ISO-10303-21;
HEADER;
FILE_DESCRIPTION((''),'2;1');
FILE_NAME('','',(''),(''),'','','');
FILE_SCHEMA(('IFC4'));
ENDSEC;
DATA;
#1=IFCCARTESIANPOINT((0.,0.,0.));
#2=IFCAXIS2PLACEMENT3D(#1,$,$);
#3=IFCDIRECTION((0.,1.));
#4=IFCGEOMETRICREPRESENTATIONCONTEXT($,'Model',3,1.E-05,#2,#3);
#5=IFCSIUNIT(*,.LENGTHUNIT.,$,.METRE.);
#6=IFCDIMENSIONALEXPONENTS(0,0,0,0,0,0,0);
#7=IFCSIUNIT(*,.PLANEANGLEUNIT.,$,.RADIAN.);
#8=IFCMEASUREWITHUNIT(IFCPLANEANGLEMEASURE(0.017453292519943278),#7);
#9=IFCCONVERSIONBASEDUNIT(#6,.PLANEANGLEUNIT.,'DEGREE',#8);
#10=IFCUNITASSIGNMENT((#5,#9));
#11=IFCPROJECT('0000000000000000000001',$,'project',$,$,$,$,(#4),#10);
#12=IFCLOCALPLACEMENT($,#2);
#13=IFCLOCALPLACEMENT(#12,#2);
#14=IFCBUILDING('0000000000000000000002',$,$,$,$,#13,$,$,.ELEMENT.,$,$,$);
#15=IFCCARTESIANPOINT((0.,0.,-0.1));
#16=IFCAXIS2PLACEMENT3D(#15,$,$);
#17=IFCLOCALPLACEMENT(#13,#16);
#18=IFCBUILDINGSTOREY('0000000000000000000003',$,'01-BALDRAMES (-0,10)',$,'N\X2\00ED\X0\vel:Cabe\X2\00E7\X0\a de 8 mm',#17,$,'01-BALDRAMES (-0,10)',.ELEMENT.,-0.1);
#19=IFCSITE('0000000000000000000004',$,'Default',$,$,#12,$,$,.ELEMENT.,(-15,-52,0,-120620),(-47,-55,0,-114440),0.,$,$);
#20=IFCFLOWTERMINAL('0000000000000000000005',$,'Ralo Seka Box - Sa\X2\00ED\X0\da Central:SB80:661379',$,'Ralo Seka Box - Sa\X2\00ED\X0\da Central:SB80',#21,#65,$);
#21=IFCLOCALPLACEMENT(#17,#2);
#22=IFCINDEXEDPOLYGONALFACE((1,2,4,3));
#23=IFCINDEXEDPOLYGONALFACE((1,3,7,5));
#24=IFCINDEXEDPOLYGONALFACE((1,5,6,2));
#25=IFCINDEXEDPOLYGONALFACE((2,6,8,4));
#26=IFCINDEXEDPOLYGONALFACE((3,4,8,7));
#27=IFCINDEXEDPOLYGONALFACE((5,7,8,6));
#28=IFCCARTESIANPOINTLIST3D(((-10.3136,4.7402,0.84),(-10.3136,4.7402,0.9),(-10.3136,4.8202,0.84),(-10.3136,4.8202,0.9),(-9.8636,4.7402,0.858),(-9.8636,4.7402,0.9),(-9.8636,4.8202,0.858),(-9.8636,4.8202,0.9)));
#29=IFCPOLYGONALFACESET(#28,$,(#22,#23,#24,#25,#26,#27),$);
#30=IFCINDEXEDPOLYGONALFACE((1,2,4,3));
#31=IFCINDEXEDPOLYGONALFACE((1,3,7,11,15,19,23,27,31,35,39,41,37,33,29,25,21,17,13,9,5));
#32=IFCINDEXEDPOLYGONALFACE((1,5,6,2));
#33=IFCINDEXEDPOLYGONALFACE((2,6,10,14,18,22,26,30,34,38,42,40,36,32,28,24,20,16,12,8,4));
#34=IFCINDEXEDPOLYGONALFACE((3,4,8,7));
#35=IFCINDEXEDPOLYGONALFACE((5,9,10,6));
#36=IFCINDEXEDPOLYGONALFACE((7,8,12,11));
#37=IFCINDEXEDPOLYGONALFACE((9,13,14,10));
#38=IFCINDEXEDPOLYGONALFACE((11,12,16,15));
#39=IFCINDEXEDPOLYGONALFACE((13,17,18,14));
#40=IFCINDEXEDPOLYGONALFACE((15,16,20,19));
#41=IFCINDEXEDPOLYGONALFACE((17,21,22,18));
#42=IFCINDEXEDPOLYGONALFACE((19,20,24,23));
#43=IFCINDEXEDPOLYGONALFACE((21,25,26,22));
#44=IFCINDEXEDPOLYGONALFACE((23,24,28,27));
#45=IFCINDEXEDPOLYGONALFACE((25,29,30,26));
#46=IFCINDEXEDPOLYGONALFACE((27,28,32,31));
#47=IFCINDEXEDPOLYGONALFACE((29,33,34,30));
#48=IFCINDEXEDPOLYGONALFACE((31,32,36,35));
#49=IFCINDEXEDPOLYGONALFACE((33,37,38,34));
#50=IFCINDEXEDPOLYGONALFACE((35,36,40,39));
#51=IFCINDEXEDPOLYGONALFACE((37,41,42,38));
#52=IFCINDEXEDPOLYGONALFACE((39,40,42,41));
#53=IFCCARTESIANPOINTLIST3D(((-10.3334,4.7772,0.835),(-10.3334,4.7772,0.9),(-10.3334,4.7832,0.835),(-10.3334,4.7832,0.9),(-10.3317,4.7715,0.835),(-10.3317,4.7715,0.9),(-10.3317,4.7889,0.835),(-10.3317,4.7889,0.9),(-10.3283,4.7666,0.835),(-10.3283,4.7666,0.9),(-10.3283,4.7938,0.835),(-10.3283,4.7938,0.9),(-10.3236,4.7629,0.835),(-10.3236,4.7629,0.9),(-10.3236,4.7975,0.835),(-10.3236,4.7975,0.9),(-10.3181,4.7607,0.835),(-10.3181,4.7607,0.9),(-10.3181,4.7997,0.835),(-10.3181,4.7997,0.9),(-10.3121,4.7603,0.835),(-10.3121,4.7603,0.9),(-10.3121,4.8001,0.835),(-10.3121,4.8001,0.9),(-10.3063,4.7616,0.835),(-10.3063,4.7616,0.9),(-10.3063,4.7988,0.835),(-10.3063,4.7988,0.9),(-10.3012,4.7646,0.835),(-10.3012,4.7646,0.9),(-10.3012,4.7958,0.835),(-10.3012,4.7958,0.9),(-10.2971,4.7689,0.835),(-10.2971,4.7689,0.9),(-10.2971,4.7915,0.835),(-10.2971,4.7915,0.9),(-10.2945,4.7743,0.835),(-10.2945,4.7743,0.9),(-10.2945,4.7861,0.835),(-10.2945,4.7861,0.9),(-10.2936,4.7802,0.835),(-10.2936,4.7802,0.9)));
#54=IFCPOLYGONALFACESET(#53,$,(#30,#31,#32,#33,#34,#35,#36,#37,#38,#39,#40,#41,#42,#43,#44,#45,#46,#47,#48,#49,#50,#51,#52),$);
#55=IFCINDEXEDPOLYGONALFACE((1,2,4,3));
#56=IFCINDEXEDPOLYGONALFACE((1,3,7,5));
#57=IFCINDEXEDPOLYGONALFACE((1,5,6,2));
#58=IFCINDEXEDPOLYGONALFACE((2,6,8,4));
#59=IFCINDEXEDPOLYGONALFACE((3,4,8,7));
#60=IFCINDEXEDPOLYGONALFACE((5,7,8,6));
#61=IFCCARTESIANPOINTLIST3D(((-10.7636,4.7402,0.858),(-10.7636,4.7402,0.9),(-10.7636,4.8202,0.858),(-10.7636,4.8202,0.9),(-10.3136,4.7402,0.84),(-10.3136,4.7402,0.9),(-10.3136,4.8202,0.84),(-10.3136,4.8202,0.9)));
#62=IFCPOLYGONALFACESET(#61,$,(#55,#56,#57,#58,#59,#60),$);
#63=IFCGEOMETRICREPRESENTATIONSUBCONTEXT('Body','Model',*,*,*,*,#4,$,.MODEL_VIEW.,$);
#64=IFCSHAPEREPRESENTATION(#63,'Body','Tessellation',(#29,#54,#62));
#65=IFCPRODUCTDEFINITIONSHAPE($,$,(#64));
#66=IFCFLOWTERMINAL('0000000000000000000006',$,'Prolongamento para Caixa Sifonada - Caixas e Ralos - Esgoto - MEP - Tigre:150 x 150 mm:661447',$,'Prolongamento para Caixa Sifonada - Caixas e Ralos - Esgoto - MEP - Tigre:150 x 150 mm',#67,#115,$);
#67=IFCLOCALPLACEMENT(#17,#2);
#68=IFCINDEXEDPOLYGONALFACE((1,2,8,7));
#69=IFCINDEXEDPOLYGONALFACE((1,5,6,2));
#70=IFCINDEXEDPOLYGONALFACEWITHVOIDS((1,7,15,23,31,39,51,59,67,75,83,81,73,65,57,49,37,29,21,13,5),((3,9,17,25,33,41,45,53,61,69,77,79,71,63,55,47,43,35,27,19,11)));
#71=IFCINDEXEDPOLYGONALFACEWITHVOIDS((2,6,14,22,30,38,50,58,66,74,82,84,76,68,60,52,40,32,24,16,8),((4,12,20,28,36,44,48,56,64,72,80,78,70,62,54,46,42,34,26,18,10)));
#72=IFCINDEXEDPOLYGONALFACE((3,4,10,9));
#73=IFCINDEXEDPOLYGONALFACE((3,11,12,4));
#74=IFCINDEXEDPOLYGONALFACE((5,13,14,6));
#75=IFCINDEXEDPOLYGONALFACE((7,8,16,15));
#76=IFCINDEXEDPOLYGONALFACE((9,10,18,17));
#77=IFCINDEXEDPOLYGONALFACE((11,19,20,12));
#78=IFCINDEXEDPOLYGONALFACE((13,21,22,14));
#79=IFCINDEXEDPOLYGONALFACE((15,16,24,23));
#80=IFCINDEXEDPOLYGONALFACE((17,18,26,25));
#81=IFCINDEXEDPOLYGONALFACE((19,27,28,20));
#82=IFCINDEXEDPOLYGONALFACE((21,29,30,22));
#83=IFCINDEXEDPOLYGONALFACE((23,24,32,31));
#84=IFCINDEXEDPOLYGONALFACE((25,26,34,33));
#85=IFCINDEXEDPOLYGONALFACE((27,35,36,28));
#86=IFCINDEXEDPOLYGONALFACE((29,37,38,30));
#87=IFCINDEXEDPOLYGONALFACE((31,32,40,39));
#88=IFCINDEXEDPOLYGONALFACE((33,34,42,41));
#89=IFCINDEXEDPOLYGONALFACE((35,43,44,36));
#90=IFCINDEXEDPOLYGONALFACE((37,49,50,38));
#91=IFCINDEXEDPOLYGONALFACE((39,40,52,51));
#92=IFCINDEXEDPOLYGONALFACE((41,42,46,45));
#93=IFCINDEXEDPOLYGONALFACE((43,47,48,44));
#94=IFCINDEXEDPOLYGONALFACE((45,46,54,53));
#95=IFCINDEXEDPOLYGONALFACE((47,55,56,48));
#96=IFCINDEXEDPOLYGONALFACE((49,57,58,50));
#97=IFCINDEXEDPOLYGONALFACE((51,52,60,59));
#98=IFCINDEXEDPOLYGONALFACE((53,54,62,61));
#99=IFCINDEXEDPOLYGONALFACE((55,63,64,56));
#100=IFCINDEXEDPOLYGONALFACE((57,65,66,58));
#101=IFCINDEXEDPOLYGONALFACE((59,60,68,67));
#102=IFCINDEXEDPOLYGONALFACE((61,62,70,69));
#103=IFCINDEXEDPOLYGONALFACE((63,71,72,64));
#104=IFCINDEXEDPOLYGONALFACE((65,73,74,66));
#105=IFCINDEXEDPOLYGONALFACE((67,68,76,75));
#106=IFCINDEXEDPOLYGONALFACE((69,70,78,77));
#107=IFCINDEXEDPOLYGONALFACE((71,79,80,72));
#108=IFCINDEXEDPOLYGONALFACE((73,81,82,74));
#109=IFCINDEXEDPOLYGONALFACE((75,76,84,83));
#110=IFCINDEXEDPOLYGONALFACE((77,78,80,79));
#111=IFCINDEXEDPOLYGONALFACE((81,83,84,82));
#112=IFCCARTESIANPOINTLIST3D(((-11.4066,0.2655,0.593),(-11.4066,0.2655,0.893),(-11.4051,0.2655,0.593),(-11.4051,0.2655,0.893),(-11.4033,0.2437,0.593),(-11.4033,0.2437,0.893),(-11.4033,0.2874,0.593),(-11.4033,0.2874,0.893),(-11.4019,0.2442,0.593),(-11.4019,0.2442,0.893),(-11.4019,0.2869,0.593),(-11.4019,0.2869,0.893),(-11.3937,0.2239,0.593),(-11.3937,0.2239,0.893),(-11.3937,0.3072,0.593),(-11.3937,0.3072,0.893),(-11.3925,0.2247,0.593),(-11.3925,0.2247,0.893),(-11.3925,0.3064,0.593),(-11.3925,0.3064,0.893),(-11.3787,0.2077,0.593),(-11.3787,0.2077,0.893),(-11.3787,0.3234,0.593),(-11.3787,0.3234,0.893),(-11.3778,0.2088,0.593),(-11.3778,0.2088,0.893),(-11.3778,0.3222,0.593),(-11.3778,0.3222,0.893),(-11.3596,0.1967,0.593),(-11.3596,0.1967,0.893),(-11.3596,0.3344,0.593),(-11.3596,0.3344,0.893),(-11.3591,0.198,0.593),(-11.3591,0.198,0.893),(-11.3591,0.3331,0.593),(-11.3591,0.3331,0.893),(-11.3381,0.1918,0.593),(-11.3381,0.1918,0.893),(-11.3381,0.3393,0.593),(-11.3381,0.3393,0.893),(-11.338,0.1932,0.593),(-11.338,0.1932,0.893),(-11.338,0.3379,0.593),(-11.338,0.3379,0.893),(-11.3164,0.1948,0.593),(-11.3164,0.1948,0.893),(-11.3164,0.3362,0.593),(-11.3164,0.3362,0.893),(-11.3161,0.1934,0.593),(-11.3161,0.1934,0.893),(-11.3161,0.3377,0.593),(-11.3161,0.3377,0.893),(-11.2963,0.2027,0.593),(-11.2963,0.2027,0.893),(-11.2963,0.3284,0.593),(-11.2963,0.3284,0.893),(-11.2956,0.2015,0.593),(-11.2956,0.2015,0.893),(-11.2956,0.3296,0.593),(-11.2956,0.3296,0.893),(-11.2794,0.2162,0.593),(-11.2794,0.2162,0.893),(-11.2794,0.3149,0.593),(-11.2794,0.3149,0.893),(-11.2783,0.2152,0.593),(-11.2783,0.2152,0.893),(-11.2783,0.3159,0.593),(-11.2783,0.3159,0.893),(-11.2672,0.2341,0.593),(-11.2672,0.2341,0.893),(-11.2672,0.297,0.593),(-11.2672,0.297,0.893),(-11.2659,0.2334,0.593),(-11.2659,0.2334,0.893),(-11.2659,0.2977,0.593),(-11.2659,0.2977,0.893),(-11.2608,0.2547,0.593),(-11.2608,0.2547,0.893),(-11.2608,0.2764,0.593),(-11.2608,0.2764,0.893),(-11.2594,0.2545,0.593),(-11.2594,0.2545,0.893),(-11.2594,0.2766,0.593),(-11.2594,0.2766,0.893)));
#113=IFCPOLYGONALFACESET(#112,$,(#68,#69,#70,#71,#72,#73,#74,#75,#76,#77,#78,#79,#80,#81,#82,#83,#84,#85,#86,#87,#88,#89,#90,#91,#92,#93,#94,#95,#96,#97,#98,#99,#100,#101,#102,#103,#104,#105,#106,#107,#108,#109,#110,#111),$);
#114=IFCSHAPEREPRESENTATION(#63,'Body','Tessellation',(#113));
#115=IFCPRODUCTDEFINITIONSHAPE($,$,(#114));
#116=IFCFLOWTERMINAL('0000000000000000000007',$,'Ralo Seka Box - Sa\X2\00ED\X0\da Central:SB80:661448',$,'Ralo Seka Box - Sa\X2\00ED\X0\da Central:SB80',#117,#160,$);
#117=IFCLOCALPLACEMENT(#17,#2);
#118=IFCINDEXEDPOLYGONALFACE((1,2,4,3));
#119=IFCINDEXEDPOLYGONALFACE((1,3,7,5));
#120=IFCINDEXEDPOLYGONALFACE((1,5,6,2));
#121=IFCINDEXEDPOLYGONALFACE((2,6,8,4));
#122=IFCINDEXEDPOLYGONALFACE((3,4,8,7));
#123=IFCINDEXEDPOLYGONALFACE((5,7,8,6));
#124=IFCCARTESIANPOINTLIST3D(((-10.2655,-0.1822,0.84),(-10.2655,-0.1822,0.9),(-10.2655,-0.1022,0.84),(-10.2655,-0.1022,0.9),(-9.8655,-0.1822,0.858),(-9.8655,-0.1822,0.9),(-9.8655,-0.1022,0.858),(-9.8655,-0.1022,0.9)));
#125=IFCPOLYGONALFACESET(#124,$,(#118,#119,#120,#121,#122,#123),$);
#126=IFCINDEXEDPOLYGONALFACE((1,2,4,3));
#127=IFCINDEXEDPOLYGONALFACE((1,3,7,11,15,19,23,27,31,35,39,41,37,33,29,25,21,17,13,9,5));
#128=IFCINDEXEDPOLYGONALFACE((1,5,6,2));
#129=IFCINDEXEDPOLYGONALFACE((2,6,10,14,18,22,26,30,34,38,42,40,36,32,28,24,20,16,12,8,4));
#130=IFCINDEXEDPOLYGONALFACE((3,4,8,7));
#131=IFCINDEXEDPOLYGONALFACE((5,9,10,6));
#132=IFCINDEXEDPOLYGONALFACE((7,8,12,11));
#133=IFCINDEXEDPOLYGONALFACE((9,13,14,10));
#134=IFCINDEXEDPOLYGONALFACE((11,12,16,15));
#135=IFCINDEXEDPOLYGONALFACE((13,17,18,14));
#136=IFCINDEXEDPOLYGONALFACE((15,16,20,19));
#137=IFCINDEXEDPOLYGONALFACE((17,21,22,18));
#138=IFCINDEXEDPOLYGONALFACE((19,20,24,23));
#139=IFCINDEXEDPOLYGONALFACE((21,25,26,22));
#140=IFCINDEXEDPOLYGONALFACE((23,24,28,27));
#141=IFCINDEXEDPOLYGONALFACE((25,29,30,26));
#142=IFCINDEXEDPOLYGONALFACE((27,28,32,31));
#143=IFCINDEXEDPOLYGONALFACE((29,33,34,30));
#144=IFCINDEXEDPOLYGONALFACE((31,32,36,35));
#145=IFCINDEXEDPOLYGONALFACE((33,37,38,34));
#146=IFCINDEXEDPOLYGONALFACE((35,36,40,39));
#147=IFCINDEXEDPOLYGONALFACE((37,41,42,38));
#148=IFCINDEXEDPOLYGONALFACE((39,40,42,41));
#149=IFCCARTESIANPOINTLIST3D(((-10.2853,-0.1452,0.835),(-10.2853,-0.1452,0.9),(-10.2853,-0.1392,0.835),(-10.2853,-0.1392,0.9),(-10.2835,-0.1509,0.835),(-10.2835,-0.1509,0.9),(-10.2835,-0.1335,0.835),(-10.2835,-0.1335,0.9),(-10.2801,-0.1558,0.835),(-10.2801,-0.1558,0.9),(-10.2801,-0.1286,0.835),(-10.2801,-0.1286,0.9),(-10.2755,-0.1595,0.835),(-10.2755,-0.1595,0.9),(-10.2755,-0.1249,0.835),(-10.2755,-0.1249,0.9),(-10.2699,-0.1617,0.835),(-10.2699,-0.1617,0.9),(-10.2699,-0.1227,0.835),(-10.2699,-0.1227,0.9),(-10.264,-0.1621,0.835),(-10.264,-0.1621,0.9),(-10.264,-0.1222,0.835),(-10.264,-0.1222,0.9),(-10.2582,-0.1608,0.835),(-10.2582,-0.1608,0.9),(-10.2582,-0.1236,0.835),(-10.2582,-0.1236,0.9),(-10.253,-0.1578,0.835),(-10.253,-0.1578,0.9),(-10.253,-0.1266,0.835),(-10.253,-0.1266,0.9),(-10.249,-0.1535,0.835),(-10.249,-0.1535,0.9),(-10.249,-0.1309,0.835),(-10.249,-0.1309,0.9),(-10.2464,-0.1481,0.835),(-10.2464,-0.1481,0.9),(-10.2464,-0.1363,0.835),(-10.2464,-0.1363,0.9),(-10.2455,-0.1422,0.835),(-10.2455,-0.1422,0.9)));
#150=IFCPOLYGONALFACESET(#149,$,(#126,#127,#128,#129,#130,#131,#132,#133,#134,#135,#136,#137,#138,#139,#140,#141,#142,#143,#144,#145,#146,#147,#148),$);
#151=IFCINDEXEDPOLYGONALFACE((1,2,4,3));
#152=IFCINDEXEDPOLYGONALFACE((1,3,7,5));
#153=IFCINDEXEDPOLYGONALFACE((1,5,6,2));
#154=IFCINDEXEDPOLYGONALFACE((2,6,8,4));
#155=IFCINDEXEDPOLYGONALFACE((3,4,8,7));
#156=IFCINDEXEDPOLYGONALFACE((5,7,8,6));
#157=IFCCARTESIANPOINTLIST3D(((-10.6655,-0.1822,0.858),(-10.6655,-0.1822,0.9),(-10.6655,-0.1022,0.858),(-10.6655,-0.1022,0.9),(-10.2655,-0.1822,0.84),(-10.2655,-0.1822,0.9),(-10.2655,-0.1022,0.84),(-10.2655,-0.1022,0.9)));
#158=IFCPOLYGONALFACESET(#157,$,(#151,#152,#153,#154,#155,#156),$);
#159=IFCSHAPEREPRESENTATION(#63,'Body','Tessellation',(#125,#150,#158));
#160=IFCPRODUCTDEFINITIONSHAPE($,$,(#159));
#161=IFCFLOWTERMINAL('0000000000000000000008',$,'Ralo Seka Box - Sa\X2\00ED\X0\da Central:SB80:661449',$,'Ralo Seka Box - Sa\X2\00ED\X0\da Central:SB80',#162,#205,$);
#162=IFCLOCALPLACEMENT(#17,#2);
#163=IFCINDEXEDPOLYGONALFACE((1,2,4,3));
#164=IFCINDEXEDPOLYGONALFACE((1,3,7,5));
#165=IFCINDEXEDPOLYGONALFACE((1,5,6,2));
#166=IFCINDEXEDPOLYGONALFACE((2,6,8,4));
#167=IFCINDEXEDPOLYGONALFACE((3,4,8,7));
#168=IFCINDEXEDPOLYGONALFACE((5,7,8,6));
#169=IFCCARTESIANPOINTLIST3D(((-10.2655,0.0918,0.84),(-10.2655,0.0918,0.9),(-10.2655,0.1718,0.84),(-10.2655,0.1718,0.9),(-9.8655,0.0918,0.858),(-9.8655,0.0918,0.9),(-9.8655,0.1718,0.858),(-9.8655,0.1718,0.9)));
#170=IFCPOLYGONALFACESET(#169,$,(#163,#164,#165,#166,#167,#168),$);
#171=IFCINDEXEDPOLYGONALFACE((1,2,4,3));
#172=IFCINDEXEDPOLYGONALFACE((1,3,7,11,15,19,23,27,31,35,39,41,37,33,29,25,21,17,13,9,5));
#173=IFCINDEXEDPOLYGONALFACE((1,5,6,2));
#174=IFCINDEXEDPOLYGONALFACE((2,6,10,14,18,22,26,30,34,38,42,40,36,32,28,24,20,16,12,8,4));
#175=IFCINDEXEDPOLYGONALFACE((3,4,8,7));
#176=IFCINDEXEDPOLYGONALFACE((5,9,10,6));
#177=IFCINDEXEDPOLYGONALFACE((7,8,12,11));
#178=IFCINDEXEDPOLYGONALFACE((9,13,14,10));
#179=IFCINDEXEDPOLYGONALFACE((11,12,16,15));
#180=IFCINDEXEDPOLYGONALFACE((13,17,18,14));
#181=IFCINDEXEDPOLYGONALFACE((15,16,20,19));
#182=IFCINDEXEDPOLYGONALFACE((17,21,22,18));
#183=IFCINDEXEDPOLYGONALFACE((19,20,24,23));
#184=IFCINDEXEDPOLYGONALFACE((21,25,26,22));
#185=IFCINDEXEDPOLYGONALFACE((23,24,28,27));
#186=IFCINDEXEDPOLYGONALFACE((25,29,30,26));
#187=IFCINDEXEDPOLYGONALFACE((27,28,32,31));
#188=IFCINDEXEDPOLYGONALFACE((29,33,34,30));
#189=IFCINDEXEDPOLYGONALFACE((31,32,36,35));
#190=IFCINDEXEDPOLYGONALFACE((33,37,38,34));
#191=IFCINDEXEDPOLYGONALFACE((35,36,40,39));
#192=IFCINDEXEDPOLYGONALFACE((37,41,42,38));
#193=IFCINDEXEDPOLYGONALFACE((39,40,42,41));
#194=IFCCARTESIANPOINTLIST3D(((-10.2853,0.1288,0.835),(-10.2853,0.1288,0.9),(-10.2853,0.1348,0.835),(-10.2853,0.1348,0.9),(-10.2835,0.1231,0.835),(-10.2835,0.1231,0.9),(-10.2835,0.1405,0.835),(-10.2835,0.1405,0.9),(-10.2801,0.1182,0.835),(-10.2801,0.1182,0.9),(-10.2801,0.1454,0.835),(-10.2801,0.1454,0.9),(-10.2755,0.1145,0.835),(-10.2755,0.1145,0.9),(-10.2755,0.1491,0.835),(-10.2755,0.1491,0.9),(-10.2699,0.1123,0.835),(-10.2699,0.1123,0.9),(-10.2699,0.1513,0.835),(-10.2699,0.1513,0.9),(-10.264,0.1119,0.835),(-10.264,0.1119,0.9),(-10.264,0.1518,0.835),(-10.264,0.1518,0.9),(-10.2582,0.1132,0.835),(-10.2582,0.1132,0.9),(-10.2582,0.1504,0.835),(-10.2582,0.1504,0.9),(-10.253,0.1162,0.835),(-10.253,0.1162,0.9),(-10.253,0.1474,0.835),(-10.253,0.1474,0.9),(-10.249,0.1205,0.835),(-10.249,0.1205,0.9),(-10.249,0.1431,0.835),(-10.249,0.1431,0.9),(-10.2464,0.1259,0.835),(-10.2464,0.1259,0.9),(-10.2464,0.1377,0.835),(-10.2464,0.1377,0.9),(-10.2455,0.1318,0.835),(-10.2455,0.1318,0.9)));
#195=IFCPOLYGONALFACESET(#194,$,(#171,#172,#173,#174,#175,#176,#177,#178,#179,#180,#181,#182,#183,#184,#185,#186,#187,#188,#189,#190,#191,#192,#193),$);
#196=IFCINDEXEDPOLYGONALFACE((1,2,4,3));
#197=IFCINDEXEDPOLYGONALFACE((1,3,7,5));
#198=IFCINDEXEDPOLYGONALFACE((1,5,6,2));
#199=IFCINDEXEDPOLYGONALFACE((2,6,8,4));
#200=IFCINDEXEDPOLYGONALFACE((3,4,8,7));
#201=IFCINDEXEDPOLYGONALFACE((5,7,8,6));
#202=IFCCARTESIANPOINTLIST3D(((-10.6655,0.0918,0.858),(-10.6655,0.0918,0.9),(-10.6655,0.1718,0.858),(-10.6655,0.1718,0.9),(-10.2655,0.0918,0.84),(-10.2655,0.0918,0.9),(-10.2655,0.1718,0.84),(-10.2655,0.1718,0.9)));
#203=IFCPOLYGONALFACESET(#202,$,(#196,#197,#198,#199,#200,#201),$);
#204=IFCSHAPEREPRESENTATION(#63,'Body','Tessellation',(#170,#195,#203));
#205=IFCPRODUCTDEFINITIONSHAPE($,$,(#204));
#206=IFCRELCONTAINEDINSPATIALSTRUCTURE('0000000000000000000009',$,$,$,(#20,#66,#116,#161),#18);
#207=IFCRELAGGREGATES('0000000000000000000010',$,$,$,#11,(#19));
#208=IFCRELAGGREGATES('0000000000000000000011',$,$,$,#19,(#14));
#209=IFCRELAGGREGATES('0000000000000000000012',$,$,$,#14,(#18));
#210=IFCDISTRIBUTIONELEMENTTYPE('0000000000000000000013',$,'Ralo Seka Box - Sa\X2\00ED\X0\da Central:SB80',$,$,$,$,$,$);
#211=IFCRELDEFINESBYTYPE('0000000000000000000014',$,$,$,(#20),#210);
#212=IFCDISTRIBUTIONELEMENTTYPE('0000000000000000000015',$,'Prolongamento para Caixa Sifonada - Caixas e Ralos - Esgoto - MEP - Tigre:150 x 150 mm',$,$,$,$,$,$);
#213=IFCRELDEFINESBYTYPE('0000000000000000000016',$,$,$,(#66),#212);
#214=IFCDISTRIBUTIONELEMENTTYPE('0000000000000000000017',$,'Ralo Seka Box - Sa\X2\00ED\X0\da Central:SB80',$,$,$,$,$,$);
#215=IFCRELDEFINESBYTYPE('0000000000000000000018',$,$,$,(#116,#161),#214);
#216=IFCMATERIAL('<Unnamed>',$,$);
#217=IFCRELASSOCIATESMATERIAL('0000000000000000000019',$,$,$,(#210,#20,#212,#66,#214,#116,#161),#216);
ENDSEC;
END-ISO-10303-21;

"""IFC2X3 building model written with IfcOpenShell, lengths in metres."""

from ifc_helpers import new_model, entity, si_unit, converted_unit, direction, frame, frame_2d, origin, place, context, subcontext, project, spatial, polyline, circle, hollow_circle, outline, extrude, source, transform, mapped, material, type_object, type_shapes, element, save


model = new_model("IFC2X3")

# Units and contexts
model_context = context("Model", 3, precision=1e-05, world=origin(), true_north=direction((0.0, 1.0)))
body_context = subcontext(model_context, "Body", "Model", "MODEL_VIEW")
ifc_project = project(units=[si_unit("LENGTHUNIT", "METRE"), converted_unit("PLANEANGLEUNIT", "DEGREE", entity("IfcPlaneAngleMeasure", 0.017453292519943278), si_unit("PLANEANGLEUNIT", "RADIAN"), dimensions=[0, 0, 0, 0, 0, 0, 0])], contexts=[model_context])

# Site, building, storey
site_placement = place(None, origin())
site = spatial("IfcSite", under=ifc_project, at=site_placement, Name="Default", CompositionType="ELEMENT", RefLatitude=(-15, -52, 0, -120620), RefLongitude=(-47, -55, 0, -114440), RefElevation=0.0)
building_placement = place(site_placement, origin())
building = spatial("IfcBuilding", under=site, at=building_placement, CompositionType="ELEMENT")
storey_placement = place(building_placement, frame((0.0, 0.0, -0.1)))
storey = spatial("IfcBuildingStorey", under=building, at=storey_placement, Name="01-BALDRAMES (-0,10)", ObjectType="Nível:Cabeça de 8 mm", LongName="01-BALDRAMES (-0,10)", CompositionType="ELEMENT", Elevation=-0.1)

# Shared definitions
ifc_material = material(Name="<Unnamed>")

# Flow terminals
distribution_element_type_1 = type_object("IfcDistributionElementType", Name="Ralo Seka Box - Saída Central:SB80", material=ifc_material)
shared_shape_1 = source(origin(), body_context, "Body", "SweptSolid", [
    extrude(outline(polyline([(-0.2242, -0.0255), (0.2262, -0.0255), (0.2238, 0.0345), (-0.2258, 0.0165), (-0.2242, -0.0255)])), frame((0.225, -0.04, -0.0255), z_axis=(0.0, 1.0, 0.0), x_axis=(-0.999201, 0.0, -0.039968)), (0.0, 0.0, 1.0), 0.08),
    extrude(circle(Radius=0.02, at=frame_2d((0.0, 0.0), x_axis=(1.0, 0.0))), frame((0.0, 0.0, -0.065)), (0.0, 0.0, 1.0), 0.065),
    extrude(outline(polyline([(-0.225, -0.0255), (0.225, -0.0255), (0.225, 0.0345), (-0.225, 0.0165), (-0.225, -0.0255)])), frame((-0.225, -0.04, -0.0255), z_axis=(0.0, 1.0, 0.0), x_axis=(1.0, 0.0, 0.0)), (0.0, 0.0, 1.0), 0.08),
])
type_shapes(distribution_element_type_1, [shared_shape_1])
flow_terminal_1_placement = place(storey_placement, frame((-10.3136, 4.7802, 0.9)))
element("IfcFlowTerminal", 1, at=flow_terminal_1_placement, inside=storey, type_object=distribution_element_type_1, material=ifc_material, Name="Ralo Seka Box - Saída Central:SB80:661379", ObjectType="Ralo Seka Box - Saída Central:SB80", context=body_context, shape_type="MappedRepresentation", body=[
    mapped(shared_shape_1, transform((0.0, 0.0, 0.0), scale=1.0)),
])
distribution_element_type_2 = type_object("IfcDistributionElementType", Name="Prolongamento para Caixa Sifonada - Caixas e Ralos - Esgoto - MEP - Tigre:150 x 150 mm", material=ifc_material)
shared_shape_2 = source(origin(), body_context, "Body", "SweptSolid", [
    extrude(hollow_circle(Radius=0.074, WallThickness=0.0015, at=frame_2d((0.0, 0.0), x_axis=(1.0, 0.0))), frame((0.0, 0.0, -0.3)), (0.0, 0.0, 1.0), 0.3),
])
type_shapes(distribution_element_type_2, [shared_shape_2])
flow_terminal_2_placement = place(storey_placement, frame((-11.3326, 0.2655, 0.893), z_axis=(0.0, 0.0, 1.0), x_axis=(-1.0, -0.000001, 0.0)))
element("IfcFlowTerminal", 2, at=flow_terminal_2_placement, inside=storey, type_object=distribution_element_type_2, material=ifc_material, Name="Prolongamento para Caixa Sifonada - Caixas e Ralos - Esgoto - MEP - Tigre:150 x 150 mm:661447", ObjectType="Prolongamento para Caixa Sifonada - Caixas e Ralos - Esgoto - MEP - Tigre:150 x 150 mm", context=body_context, shape_type="MappedRepresentation", body=[
    mapped(shared_shape_2, transform((0.0, 0.0, 0.0), scale=1.0)),
])
distribution_element_type_3 = type_object("IfcDistributionElementType", Name="Ralo Seka Box - Saída Central:SB80", material=ifc_material)
shared_shape_3 = source(origin(), body_context, "Body", "SweptSolid", [
    extrude(outline(polyline([(-0.1991, -0.0255), (0.2013, -0.0255), (0.1987, 0.0345), (-0.2009, 0.0165), (-0.1991, -0.0255)])), frame((0.2, -0.04, -0.0255), z_axis=(0.0, 1.0, 0.0), x_axis=(-0.998989, 0.0, -0.044955)), (0.0, 0.0, 1.0), 0.08),
    extrude(circle(Radius=0.02, at=frame_2d((0.0, 0.0), x_axis=(1.0, 0.0))), frame((0.0, 0.0, -0.065)), (0.0, 0.0, 1.0), 0.065),
    extrude(outline(polyline([(-0.2, -0.0255), (0.2, -0.0255), (0.2, 0.0345), (-0.2, 0.0165), (-0.2, -0.0255)])), frame((-0.2, -0.04, -0.0255), z_axis=(0.0, 1.0, 0.0), x_axis=(1.0, 0.0, 0.0)), (0.0, 0.0, 1.0), 0.08),
])
type_shapes(distribution_element_type_3, [shared_shape_3])
for number, where, name in (
    (3, (-10.2655, -0.1422, 0.9), "Ralo Seka Box - Saída Central:SB80:661448"),
    (4, (-10.2655, 0.1318, 0.9), "Ralo Seka Box - Saída Central:SB80:661449"),
):
    element("IfcFlowTerminal", number, at=place(storey_placement, frame(where)), inside=storey, type_object=distribution_element_type_3, material=ifc_material, Name=name, ObjectType="Ralo Seka Box - Saída Central:SB80", context=body_context, shape_type="MappedRepresentation", body=[
        mapped(shared_shape_3, transform((0.0, 0.0, 0.0), scale=1.0)),
    ])

save(model, "model.ifc")
